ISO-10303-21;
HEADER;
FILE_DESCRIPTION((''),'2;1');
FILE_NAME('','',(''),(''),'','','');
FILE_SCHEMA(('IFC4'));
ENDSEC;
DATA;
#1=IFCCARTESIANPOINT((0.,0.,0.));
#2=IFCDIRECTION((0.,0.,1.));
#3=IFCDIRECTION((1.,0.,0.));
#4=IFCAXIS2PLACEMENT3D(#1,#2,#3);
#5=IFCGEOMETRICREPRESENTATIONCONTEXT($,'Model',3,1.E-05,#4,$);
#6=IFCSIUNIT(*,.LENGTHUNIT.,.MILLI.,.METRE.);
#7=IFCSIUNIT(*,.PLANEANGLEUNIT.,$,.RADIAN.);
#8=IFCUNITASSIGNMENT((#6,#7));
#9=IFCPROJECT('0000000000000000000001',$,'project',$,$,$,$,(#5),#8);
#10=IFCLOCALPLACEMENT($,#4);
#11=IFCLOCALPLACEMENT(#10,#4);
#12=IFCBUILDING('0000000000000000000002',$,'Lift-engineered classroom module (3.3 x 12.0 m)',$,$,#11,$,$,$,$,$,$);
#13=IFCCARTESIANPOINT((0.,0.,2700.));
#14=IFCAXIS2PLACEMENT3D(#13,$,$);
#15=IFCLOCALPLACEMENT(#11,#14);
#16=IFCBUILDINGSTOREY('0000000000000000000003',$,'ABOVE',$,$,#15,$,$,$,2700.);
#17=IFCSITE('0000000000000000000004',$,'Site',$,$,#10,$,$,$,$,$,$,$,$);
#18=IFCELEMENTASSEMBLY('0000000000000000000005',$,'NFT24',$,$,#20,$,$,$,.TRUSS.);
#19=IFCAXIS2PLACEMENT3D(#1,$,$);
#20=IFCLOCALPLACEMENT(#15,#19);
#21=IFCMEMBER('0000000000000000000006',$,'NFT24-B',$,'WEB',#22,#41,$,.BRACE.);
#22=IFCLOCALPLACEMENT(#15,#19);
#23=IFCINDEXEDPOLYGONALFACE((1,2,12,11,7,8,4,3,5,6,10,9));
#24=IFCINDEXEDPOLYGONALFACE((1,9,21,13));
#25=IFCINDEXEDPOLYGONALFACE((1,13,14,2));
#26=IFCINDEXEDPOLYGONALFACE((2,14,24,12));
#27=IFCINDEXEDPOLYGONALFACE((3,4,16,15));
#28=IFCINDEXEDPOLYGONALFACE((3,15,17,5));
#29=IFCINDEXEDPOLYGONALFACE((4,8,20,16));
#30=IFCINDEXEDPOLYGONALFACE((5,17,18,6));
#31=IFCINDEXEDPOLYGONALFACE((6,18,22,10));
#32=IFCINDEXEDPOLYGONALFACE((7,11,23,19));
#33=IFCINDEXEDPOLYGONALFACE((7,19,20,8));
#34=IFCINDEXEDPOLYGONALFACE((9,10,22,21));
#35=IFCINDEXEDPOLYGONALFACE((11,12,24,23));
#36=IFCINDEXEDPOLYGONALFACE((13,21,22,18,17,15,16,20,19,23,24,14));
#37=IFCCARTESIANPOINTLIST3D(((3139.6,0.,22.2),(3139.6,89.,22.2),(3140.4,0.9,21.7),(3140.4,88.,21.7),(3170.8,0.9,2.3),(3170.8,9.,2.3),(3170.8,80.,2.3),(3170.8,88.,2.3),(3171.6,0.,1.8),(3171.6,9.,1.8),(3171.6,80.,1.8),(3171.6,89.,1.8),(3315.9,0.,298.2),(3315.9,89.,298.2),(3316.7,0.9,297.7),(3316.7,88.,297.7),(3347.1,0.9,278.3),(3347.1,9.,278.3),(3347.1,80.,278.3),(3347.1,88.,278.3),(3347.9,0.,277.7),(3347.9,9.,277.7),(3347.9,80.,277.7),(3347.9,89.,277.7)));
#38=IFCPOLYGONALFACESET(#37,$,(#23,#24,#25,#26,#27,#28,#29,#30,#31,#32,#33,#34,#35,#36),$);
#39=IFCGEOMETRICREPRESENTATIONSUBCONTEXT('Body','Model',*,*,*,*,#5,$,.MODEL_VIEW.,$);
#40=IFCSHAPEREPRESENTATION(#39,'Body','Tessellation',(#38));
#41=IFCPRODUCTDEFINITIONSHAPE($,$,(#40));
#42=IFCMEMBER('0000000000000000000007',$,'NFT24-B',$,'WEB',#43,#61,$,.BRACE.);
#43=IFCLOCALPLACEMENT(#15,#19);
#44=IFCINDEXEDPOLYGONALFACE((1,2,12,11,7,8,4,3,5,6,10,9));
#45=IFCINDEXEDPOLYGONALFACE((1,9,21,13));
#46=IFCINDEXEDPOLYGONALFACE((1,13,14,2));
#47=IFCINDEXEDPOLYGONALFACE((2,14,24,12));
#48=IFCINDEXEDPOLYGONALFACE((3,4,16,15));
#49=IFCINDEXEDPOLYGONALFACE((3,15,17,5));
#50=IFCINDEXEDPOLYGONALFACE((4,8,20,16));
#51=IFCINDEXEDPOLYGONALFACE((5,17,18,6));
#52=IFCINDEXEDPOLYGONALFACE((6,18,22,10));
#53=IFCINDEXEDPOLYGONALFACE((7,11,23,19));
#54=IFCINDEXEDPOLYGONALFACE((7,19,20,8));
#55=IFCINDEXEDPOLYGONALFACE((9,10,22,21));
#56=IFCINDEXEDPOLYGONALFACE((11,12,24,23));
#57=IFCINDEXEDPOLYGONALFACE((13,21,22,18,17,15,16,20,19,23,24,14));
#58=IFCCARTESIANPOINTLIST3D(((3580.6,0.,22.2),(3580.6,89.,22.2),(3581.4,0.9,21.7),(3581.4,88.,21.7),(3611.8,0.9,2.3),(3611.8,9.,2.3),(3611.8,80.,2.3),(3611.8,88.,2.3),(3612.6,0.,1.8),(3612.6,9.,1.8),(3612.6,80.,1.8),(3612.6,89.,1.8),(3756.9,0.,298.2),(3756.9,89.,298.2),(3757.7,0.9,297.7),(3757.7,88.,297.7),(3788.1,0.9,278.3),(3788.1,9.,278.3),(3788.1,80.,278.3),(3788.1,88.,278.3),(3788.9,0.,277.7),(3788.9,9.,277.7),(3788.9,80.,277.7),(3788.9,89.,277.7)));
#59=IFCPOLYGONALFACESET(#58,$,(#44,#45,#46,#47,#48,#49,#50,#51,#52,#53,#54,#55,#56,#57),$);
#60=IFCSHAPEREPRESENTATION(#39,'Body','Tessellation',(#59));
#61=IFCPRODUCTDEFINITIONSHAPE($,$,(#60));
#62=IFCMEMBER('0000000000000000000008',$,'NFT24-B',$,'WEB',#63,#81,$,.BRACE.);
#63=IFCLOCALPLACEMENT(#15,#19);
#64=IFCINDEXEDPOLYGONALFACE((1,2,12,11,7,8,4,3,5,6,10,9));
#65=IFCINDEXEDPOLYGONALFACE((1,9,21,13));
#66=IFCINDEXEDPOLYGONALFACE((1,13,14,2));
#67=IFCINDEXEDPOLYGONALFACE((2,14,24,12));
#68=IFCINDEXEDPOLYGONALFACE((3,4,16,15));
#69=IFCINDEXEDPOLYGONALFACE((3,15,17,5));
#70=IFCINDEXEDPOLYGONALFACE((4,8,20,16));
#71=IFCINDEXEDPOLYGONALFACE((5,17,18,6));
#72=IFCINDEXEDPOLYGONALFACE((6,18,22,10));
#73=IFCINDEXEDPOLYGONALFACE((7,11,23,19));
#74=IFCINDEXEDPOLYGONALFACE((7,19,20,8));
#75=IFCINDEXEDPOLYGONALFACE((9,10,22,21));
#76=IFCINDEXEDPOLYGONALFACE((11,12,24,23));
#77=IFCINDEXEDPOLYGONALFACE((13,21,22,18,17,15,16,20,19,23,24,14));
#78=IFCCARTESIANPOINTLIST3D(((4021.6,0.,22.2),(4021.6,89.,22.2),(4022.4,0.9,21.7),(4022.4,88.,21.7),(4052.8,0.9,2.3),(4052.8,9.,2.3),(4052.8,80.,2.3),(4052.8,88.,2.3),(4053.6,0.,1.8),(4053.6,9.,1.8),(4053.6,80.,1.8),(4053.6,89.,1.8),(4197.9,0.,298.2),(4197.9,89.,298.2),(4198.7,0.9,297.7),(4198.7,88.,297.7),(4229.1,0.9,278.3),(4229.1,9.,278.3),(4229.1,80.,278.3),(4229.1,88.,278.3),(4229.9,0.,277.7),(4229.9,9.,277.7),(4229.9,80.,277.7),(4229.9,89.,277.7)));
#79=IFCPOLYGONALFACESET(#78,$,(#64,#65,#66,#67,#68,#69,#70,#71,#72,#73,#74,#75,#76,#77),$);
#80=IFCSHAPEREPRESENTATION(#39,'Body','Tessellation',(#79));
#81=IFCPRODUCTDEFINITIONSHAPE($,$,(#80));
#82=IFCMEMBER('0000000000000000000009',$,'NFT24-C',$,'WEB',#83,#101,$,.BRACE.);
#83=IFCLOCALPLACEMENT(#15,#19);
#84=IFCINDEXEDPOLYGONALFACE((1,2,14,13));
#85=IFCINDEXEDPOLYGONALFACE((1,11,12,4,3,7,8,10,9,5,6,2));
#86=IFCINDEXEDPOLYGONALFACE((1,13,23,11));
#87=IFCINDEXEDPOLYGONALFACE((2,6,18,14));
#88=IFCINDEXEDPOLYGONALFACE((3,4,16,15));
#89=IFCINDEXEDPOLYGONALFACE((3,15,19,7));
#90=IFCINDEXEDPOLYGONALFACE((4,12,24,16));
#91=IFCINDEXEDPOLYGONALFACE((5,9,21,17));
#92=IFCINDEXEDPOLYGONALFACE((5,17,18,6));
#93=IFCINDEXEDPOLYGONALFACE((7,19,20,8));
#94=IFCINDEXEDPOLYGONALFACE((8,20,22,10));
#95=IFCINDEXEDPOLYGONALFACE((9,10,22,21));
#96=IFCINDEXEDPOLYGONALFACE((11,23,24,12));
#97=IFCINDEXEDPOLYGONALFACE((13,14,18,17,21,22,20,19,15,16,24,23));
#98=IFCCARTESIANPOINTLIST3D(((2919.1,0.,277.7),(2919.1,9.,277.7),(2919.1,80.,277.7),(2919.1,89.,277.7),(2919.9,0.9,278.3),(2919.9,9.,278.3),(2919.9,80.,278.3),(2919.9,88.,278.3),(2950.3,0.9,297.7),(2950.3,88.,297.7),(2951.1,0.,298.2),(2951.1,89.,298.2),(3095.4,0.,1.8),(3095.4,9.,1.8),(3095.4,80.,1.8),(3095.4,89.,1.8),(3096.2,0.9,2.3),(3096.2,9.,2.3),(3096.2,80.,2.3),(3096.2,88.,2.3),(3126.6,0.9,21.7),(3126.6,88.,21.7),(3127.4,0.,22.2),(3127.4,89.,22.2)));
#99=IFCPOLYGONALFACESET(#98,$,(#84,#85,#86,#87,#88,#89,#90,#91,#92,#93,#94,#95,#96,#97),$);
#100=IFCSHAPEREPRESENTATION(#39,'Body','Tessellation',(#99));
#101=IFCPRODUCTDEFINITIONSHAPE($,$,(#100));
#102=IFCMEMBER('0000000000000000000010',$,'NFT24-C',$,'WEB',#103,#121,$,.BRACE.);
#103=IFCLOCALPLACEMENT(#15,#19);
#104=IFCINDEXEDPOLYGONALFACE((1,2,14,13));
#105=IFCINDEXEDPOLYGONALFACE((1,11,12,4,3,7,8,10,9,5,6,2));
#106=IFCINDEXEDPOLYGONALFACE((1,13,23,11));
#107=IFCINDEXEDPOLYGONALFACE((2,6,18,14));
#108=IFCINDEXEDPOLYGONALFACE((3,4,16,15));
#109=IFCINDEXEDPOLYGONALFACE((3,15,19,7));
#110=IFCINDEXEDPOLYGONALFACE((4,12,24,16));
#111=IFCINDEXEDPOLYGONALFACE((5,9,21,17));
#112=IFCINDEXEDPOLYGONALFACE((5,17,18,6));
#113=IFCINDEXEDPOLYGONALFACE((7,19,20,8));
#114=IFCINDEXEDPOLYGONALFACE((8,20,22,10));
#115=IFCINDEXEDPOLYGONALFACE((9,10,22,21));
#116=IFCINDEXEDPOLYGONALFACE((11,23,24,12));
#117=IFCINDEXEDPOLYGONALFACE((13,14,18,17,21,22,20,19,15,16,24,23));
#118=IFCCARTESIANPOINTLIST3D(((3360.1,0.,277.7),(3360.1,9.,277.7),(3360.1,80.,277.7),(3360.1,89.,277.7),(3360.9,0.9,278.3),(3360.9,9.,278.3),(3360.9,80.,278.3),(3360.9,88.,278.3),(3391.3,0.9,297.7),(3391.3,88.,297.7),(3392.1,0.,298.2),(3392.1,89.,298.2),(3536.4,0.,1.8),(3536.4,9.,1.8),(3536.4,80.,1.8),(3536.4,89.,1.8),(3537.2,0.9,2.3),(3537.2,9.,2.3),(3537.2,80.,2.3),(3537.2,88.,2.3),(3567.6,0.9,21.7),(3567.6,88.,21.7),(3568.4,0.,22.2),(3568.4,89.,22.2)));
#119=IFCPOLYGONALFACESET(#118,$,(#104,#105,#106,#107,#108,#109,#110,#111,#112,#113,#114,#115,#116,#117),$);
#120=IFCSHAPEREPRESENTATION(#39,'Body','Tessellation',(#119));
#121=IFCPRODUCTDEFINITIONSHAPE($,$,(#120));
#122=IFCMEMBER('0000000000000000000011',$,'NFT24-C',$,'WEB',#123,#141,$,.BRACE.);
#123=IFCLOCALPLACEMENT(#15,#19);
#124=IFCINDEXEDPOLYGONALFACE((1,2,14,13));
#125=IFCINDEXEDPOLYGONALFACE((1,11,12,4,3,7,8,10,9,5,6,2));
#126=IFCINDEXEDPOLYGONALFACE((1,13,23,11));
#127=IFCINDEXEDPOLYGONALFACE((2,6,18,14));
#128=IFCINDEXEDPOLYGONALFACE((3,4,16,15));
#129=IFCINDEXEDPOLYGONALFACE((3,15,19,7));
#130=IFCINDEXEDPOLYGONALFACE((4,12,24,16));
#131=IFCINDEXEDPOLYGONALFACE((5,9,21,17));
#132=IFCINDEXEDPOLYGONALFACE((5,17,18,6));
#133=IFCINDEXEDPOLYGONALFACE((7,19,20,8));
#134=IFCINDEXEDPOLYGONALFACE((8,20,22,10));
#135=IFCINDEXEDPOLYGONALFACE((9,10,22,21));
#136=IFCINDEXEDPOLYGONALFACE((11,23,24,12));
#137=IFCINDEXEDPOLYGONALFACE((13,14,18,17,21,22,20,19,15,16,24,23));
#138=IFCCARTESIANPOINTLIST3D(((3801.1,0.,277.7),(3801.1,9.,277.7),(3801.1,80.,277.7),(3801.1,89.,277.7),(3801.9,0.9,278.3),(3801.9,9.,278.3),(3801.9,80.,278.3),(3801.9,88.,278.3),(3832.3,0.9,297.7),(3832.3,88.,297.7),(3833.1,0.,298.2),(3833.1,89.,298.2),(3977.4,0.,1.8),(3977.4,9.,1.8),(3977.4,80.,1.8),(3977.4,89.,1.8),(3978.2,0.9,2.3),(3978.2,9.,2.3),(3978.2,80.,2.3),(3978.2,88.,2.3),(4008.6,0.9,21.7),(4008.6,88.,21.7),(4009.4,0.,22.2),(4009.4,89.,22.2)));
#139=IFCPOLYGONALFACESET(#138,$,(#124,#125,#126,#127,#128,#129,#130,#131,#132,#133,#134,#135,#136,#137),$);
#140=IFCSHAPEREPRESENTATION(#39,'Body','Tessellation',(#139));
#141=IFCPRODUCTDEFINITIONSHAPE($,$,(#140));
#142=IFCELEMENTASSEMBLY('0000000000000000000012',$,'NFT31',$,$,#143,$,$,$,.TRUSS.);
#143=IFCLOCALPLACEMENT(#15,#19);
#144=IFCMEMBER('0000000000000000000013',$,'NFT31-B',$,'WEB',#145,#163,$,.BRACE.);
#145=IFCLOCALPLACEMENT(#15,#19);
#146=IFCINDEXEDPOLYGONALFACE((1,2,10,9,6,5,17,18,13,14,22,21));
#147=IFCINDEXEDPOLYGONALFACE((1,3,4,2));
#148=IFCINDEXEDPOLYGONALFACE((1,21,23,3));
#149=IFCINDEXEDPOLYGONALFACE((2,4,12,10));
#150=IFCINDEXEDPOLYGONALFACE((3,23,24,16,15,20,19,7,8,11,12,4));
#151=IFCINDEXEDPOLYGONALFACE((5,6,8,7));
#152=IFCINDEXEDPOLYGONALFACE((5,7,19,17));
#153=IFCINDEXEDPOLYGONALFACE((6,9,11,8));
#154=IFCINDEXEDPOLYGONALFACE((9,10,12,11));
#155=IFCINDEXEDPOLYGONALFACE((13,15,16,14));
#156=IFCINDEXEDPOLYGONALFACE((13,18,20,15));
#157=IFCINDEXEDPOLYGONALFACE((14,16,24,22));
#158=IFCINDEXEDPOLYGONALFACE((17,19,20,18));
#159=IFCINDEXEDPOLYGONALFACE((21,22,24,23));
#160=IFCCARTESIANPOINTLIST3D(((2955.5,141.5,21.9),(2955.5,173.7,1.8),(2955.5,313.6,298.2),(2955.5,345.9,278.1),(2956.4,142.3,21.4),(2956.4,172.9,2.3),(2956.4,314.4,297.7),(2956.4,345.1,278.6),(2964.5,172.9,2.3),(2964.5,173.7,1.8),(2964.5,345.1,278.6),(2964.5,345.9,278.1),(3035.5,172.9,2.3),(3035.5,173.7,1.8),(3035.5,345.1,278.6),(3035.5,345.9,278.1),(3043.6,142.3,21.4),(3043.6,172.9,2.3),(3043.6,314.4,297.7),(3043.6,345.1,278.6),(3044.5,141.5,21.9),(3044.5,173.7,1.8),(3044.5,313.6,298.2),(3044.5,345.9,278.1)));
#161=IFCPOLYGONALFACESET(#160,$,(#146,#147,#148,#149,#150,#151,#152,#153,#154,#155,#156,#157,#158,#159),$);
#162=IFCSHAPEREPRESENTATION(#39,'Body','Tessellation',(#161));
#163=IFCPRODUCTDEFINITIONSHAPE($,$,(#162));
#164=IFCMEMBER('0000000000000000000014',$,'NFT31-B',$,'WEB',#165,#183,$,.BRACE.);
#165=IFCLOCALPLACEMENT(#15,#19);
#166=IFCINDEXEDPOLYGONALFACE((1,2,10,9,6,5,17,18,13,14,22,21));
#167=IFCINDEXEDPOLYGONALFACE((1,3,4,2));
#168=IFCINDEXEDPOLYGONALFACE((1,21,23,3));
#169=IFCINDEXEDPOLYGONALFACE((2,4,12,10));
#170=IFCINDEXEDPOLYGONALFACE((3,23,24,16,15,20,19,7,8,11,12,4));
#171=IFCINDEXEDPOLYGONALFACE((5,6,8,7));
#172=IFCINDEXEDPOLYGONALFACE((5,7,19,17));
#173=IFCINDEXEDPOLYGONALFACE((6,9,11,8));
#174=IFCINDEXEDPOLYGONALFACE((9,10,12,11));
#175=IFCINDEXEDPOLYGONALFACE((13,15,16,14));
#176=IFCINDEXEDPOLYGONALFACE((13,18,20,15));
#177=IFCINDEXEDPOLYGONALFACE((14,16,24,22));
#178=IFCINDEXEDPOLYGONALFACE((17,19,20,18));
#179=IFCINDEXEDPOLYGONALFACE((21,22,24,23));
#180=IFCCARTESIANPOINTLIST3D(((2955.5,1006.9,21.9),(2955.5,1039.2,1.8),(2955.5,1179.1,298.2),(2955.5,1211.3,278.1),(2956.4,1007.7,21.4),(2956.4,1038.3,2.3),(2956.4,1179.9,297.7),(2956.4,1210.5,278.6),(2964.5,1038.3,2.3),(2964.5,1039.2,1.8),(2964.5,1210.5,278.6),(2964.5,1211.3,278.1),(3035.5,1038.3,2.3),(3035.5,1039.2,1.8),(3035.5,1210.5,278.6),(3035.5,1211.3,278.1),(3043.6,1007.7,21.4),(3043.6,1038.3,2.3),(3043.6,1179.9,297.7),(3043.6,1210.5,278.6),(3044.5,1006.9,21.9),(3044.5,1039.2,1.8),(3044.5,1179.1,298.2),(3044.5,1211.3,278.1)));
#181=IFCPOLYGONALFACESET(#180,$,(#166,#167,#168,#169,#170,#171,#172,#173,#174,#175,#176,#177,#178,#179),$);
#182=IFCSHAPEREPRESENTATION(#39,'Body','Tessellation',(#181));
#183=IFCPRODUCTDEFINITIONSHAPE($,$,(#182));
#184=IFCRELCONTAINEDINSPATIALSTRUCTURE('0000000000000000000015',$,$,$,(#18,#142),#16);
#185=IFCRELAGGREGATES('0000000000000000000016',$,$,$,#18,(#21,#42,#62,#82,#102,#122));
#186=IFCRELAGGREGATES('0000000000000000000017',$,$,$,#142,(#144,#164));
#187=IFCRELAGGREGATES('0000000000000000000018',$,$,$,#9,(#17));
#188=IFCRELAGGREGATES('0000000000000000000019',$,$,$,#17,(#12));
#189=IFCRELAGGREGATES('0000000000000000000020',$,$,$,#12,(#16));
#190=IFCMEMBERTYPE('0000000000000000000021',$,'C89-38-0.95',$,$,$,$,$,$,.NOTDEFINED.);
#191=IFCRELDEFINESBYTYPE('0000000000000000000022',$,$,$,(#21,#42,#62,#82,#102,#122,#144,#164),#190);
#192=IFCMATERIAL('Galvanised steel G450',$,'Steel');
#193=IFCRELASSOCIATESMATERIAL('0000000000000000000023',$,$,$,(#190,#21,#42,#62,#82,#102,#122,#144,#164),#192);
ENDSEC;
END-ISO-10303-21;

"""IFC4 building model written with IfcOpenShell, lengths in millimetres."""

from ifc_helpers import new_model, si_unit, frame, origin, origin_with_axes, origin_2d, place, context, subcontext, project, spatial, c_section, extrude, material, material_profile, profile_set, profile_usage, type_object, element, aggregate, save


model = new_model("IFC4")

# Units and contexts
model_context = context("Model", 3, precision=1e-05, world=origin_with_axes())
body_context = subcontext(model_context, "Body", "Model", "MODEL_VIEW")
ifc_project = project(units=[si_unit("LENGTHUNIT", "METRE", prefix="MILLI"), si_unit("PLANEANGLEUNIT", "RADIAN")], contexts=[model_context])

# Site, building, storey
site_placement = place(None, origin_with_axes())
site = spatial("IfcSite", under=ifc_project, at=site_placement, Name="Site")
building_placement = place(site_placement, origin_with_axes())
building = spatial("IfcBuilding", under=site, at=building_placement, Name="Lift-engineered classroom module (3.3 x 12.0 m)")
storey_placement = place(building_placement, frame((0.0, 0.0, 2700.0)))
storey = spatial("IfcBuildingStorey", under=building, at=storey_placement, Name="ABOVE", Elevation=2700.0)

# Element assemblies, members
assembly_1_placement = place(storey_placement, frame((0.0, 44.5, 0.0)))
assembly_1 = element("IfcElementAssembly", 1, at=assembly_1_placement, inside=storey, Name="NFT24", PredefinedType="TRUSS")
ifc_material = material(Name="Galvanised steel G450", Category="Steel")
ifc_material_profile = material_profile(ifc_material, c_section(Depth=89.0, Width=38.0, WallThickness=0.9, Girth=9.0, at=origin_2d()), Name="C89-38-0.95")
ifc_profile_set = profile_set([ifc_material_profile], Name="C89-38-0.95")
ifc_profile_usage = profile_usage(ifc_profile_set)
member_type = type_object("IfcMemberType", Name="C89-38-0.95", PredefinedType="NOTDEFINED", material=ifc_profile_set)
member_1_placement = place(assembly_1_placement, frame((3155.6, 0.0, 12.0), z_axis=(0.538459, 0.0, 0.842652), x_axis=(0.842652, 0.0, -0.538459)))
member_1 = element("IfcMember", 2, at=member_1_placement, type_object=member_type, material=ifc_profile_usage, Name="NFT24-B", ObjectType="WEB", PredefinedType="BRACE", context=body_context, shape_type="SweptSolid", body=[
    extrude(c_section(Depth=89.0, Width=38.0, WallThickness=0.9, Girth=9.0, at=origin_2d()), origin(), (0.0, 0.0, 1.0), 327.5),
])
member_2_placement = place(assembly_1_placement, frame((3596.6, 0.0, 12.0), z_axis=(0.538459, 0.0, 0.842652), x_axis=(0.842652, 0.0, -0.538459)))
member_2 = element("IfcMember", 3, at=member_2_placement, type_object=member_type, material=ifc_profile_usage, Name="NFT24-B", ObjectType="WEB", PredefinedType="BRACE", context=body_context, shape_type="SweptSolid", body=[
    extrude(c_section(Depth=89.0, Width=38.0, WallThickness=0.9, Girth=9.0, at=origin_2d()), origin(), (0.0, 0.0, 1.0), 327.5),
])
member_3_placement = place(assembly_1_placement, frame((4037.6, 0.0, 12.0), z_axis=(0.538459, 0.0, 0.842652), x_axis=(0.842652, 0.0, -0.538459)))
member_3 = element("IfcMember", 4, at=member_3_placement, type_object=member_type, material=ifc_profile_usage, Name="NFT24-B", ObjectType="WEB", PredefinedType="BRACE", context=body_context, shape_type="SweptSolid", body=[
    extrude(c_section(Depth=89.0, Width=38.0, WallThickness=0.9, Girth=9.0, at=origin_2d()), origin(), (0.0, 0.0, 1.0), 327.5),
])
member_4_placement = place(assembly_1_placement, frame((3111.4, 0.0, 12.0), z_axis=(-0.538459, 0.0, 0.842652), x_axis=(-0.842652, 0.0, -0.538459)))
member_4 = element("IfcMember", 5, at=member_4_placement, type_object=member_type, material=ifc_profile_usage, Name="NFT24-C", ObjectType="WEB", PredefinedType="BRACE", context=body_context, shape_type="SweptSolid", body=[
    extrude(c_section(Depth=89.0, Width=38.0, WallThickness=0.9, Girth=9.0, at=origin_2d()), origin(), (0.0, 0.0, 1.0), 327.5),
])
member_5_placement = place(assembly_1_placement, frame((3552.4, 0.0, 12.0), z_axis=(-0.538459, 0.0, 0.842652), x_axis=(-0.842652, 0.0, -0.538459)))
member_5 = element("IfcMember", 6, at=member_5_placement, type_object=member_type, material=ifc_profile_usage, Name="NFT24-C", ObjectType="WEB", PredefinedType="BRACE", context=body_context, shape_type="SweptSolid", body=[
    extrude(c_section(Depth=89.0, Width=38.0, WallThickness=0.9, Girth=9.0, at=origin_2d()), origin(), (0.0, 0.0, 1.0), 327.5),
])
member_6_placement = place(assembly_1_placement, frame((3993.4, 0.0, 12.0), z_axis=(-0.538459, 0.0, 0.842652), x_axis=(-0.842652, 0.0, -0.538459)))
member_6 = element("IfcMember", 7, at=member_6_placement, type_object=member_type, material=ifc_profile_usage, Name="NFT24-C", ObjectType="WEB", PredefinedType="BRACE", context=body_context, shape_type="SweptSolid", body=[
    extrude(c_section(Depth=89.0, Width=38.0, WallThickness=0.9, Girth=9.0, at=origin_2d()), origin(), (0.0, 0.0, 1.0), 327.5),
])
aggregate(assembly_1, [member_1, member_2, member_3, member_4, member_5, member_6])
assembly_2_placement = place(storey_placement, frame((3000.0, 89.0, 0.0)))
assembly_2 = element("IfcElementAssembly", 8, at=assembly_2_placement, inside=storey, Name="NFT31", PredefinedType="TRUSS")
member_7_placement = place(assembly_2_placement, frame((0.0, 68.6, 11.8), z_axis=(0.0, 0.528797, 0.848748), x_axis=(0.0, 0.848748, -0.528797)))
member_7 = element("IfcMember", 9, at=member_7_placement, type_object=member_type, material=ifc_profile_usage, Name="NFT31-B", ObjectType="WEB", PredefinedType="BRACE", context=body_context, shape_type="SweptSolid", body=[
    extrude(c_section(Depth=89.0, Width=38.0, WallThickness=0.9, Girth=9.0, at=origin_2d()), origin(), (0.0, 0.0, 1.0), 325.6),
])
member_8_placement = place(assembly_2_placement, frame((0.0, 934.0, 11.8), z_axis=(0.0, 0.528797, 0.848748), x_axis=(0.0, 0.848748, -0.528797)))
member_8 = element("IfcMember", 10, at=member_8_placement, type_object=member_type, material=ifc_profile_usage, Name="NFT31-B", ObjectType="WEB", PredefinedType="BRACE", context=body_context, shape_type="SweptSolid", body=[
    extrude(c_section(Depth=89.0, Width=38.0, WallThickness=0.9, Girth=9.0, at=origin_2d()), origin(), (0.0, 0.0, 1.0), 325.6),
])
aggregate(assembly_2, [member_7, member_8])

save(model, "model.ifc")
